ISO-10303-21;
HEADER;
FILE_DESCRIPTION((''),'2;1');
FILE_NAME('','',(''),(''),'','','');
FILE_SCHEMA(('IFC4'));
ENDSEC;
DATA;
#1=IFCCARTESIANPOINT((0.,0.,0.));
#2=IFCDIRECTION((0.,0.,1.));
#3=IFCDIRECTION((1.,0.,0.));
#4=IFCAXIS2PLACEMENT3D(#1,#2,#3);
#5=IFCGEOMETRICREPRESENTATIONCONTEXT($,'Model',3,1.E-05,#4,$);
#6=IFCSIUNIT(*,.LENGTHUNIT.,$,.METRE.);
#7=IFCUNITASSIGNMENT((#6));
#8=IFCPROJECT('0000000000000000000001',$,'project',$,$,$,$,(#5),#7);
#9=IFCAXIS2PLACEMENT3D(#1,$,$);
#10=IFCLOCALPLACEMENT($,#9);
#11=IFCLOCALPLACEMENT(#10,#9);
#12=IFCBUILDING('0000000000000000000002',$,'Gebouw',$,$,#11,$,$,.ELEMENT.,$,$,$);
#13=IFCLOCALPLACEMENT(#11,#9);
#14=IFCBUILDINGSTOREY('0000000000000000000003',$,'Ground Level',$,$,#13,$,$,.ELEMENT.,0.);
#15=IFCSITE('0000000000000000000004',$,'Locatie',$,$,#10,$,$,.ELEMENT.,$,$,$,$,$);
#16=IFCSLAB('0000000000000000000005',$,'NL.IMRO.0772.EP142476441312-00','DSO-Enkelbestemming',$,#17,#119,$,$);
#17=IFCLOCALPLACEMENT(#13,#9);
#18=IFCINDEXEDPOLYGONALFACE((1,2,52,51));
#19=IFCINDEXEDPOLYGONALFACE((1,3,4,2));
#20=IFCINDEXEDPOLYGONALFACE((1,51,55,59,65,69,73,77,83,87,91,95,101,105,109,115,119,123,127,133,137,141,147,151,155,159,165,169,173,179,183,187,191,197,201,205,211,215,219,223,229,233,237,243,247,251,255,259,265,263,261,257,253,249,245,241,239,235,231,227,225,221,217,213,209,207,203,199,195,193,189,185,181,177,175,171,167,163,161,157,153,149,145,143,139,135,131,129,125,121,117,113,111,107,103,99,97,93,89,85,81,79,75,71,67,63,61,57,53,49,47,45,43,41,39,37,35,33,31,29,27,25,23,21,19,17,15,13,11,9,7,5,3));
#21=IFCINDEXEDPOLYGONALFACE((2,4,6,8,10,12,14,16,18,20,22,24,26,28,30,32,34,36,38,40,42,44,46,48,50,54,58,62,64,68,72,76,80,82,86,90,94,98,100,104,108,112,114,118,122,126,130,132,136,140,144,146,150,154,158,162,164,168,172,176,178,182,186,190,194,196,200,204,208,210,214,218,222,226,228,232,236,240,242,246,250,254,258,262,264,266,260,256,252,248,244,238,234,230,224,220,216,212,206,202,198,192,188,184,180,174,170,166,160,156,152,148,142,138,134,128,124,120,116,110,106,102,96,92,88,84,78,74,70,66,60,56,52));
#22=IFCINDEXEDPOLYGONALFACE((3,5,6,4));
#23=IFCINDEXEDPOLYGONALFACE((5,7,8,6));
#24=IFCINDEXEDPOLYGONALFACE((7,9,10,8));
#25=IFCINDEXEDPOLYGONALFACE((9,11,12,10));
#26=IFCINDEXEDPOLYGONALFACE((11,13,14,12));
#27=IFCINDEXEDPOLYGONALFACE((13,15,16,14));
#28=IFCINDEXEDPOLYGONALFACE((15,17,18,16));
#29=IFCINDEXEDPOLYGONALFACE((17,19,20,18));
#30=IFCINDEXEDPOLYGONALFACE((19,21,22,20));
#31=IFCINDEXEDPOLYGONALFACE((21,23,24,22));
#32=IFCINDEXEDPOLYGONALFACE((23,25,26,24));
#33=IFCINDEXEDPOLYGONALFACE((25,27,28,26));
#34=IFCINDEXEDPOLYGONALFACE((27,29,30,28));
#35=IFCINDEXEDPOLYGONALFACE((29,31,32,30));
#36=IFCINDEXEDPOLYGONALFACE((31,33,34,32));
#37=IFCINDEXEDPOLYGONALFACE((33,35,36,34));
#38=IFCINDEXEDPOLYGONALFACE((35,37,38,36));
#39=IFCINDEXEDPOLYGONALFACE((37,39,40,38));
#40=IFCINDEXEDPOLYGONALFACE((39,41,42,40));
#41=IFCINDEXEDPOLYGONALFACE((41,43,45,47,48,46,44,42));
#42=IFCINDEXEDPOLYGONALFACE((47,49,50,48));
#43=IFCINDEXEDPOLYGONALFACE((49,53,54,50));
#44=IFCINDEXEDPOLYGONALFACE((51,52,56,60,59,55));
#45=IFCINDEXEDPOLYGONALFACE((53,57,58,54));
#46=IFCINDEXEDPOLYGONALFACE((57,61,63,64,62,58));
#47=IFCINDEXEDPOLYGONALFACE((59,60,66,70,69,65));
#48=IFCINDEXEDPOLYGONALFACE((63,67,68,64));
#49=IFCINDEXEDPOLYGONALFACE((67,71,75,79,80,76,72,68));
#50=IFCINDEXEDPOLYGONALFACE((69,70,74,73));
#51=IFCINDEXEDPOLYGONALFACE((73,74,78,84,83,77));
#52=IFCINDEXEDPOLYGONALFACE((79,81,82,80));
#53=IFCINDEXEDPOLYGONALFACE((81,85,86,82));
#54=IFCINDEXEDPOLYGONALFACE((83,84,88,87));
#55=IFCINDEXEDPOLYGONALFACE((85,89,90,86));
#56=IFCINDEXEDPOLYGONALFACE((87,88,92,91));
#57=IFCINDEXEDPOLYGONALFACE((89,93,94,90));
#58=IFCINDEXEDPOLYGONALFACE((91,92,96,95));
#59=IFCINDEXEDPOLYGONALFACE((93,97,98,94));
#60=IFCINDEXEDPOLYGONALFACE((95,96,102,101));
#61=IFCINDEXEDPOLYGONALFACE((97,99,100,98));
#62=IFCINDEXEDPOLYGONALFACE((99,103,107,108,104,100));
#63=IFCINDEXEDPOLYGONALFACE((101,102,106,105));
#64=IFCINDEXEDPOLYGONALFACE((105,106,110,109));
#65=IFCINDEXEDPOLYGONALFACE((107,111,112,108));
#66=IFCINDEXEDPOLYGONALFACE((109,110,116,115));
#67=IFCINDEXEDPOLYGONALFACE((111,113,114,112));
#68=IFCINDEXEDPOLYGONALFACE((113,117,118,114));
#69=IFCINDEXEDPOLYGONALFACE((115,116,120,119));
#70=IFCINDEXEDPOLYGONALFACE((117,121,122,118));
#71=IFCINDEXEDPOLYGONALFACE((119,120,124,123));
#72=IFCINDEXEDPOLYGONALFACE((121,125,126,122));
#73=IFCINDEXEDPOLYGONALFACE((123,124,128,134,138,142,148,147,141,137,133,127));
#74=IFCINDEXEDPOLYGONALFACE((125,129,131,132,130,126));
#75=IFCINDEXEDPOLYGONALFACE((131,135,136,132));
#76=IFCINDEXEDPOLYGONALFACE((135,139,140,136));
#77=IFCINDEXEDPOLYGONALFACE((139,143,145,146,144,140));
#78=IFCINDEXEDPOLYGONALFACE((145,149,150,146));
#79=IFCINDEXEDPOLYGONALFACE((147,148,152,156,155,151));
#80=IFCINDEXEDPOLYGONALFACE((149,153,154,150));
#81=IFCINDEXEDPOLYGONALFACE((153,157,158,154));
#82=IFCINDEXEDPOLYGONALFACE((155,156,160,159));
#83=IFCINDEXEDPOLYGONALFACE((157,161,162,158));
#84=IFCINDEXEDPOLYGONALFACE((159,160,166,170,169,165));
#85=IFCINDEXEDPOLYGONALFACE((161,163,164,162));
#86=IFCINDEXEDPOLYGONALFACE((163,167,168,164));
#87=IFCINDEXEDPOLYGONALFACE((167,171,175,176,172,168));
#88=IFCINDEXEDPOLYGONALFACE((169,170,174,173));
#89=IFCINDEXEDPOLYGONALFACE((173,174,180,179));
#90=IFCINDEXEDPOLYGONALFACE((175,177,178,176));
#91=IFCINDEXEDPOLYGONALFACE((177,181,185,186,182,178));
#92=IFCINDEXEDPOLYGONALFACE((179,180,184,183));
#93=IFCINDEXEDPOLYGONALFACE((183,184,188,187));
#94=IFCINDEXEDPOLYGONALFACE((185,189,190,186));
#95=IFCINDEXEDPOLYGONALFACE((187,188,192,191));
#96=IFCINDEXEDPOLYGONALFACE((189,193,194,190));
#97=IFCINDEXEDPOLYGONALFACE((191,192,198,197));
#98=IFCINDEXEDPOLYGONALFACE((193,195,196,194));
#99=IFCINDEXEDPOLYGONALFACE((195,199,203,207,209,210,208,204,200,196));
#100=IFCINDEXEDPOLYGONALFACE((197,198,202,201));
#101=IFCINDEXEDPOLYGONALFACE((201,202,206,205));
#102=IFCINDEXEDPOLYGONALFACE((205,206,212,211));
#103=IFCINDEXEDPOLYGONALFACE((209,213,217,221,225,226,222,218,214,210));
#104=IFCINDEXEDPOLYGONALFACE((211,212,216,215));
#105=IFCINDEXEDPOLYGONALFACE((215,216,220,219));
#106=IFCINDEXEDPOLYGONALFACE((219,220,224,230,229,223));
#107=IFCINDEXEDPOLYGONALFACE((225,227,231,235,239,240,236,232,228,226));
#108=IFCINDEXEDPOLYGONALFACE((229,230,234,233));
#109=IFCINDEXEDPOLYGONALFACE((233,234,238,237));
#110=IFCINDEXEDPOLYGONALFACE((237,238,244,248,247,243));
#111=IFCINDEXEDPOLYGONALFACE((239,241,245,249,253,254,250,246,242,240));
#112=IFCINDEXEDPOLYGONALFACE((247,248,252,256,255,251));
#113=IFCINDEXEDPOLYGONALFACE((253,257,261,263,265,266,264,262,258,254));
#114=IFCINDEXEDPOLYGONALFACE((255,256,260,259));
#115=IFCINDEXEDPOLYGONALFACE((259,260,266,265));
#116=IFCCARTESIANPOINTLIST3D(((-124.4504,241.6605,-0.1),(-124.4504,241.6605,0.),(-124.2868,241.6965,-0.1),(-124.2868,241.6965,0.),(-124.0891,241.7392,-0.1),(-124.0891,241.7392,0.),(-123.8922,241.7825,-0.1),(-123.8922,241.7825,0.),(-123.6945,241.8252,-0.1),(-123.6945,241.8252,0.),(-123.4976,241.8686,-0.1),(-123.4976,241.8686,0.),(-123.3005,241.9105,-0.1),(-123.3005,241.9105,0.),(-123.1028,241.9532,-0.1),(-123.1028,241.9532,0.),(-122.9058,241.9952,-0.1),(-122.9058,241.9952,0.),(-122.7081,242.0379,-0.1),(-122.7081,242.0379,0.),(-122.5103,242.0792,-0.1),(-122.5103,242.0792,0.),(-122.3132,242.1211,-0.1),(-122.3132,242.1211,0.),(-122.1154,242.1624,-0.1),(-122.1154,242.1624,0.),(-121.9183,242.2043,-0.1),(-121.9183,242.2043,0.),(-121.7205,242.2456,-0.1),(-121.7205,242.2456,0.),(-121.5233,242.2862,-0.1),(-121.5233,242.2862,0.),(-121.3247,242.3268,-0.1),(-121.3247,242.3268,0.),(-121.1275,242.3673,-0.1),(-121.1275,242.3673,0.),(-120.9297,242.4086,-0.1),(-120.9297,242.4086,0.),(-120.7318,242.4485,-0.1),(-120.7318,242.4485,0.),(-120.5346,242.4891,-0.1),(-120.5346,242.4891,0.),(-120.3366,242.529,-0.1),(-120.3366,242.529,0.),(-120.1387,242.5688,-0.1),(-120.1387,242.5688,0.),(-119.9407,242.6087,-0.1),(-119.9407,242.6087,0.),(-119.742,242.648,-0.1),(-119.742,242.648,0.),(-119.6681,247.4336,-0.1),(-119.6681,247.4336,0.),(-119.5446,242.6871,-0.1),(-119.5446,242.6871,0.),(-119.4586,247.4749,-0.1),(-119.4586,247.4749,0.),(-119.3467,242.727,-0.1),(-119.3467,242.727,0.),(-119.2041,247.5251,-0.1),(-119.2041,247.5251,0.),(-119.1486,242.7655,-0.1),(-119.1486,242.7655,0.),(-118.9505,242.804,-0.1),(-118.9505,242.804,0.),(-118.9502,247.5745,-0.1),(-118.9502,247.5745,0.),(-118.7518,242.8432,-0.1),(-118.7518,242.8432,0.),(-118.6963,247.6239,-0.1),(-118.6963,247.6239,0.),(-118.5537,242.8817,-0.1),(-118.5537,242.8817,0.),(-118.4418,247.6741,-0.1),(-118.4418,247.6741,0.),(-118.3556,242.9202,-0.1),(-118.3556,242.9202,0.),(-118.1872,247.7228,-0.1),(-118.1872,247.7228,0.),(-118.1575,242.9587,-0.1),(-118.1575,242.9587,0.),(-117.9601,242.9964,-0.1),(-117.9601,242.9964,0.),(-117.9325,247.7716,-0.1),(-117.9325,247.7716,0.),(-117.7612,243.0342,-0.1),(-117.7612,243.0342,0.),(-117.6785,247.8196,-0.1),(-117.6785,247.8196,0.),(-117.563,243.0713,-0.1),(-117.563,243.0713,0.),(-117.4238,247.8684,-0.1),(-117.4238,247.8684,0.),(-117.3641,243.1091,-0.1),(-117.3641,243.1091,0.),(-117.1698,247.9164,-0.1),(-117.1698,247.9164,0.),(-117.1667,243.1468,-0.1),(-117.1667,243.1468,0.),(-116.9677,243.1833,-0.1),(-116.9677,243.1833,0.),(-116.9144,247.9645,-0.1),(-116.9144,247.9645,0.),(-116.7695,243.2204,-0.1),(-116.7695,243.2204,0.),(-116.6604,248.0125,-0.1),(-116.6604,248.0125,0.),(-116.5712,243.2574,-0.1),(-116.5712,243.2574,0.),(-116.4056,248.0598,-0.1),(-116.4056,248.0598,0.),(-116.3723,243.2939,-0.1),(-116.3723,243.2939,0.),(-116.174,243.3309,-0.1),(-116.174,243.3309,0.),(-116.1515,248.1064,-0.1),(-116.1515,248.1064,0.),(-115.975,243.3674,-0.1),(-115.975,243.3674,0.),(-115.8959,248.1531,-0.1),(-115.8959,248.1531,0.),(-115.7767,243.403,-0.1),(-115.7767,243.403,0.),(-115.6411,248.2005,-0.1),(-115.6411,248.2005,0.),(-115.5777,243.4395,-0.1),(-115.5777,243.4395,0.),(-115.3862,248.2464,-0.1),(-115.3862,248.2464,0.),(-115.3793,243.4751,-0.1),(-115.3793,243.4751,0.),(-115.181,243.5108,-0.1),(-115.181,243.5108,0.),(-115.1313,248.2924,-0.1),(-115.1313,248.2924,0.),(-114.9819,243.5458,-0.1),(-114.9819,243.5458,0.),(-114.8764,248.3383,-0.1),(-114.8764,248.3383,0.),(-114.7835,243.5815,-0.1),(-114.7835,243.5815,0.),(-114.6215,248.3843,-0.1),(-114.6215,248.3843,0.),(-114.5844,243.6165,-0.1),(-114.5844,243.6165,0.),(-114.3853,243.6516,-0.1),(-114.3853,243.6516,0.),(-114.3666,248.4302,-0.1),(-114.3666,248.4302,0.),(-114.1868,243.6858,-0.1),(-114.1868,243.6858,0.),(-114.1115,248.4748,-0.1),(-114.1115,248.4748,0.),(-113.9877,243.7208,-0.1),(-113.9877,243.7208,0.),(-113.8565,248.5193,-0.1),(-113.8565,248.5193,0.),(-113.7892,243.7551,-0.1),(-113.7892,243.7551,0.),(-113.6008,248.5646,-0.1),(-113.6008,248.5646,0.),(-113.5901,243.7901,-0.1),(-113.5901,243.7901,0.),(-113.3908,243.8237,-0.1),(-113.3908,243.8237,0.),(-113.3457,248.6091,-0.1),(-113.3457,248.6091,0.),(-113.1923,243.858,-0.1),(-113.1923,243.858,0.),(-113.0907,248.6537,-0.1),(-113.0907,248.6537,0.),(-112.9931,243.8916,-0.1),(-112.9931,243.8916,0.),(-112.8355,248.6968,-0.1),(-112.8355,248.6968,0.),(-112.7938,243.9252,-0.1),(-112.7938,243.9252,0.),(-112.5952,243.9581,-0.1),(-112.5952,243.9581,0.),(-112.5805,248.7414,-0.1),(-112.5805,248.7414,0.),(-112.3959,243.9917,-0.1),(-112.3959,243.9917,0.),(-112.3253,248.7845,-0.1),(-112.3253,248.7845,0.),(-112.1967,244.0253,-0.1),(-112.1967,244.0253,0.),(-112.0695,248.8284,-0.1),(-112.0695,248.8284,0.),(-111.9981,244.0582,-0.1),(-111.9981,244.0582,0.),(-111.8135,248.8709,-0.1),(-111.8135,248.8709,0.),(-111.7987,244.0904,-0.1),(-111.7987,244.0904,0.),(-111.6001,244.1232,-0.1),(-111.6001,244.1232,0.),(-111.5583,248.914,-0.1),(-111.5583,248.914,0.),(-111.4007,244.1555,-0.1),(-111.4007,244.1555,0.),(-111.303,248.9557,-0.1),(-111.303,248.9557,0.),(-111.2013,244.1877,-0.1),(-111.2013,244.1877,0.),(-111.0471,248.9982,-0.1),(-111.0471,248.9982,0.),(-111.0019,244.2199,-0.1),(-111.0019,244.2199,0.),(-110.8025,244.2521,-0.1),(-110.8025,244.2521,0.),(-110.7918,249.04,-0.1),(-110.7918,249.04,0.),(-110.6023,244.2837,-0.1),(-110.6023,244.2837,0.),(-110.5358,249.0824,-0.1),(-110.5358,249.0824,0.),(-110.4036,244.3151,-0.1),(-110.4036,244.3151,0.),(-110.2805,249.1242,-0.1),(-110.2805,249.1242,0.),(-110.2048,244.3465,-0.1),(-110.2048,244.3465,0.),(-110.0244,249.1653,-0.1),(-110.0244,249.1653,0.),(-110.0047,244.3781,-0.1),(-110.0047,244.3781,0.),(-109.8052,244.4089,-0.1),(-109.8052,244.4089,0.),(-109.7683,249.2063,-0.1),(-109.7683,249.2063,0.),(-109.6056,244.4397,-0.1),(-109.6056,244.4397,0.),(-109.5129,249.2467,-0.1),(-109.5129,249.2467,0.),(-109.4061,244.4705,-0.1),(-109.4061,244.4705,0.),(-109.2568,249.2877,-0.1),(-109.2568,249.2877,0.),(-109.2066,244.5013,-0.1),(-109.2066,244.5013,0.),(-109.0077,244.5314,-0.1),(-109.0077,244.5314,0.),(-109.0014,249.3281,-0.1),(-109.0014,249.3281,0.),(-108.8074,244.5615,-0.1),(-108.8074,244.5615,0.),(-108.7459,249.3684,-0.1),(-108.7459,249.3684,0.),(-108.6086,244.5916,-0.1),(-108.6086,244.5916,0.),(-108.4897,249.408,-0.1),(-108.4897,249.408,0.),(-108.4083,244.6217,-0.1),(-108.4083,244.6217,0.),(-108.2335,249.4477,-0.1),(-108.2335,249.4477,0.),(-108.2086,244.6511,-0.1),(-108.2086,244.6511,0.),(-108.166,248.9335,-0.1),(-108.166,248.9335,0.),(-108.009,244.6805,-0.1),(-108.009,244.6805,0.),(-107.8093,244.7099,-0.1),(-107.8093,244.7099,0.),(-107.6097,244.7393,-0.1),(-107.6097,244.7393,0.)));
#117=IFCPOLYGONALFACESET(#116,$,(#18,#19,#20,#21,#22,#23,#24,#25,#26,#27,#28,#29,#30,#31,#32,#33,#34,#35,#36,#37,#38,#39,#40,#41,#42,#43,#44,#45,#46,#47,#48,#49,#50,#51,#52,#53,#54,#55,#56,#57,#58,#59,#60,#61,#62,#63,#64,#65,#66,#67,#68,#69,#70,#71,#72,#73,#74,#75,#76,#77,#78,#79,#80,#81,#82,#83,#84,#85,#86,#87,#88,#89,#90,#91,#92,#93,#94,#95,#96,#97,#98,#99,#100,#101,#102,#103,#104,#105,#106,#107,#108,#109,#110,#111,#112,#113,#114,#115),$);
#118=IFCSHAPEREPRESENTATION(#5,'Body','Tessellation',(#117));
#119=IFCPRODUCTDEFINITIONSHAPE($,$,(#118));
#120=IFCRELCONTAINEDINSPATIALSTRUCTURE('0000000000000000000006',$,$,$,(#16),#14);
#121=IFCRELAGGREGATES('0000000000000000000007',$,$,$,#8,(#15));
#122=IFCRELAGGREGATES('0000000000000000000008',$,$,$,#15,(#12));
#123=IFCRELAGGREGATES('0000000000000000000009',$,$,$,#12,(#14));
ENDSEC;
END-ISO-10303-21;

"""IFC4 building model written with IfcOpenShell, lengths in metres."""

from ifc_helpers import new_model, si_unit, frame, origin, origin_with_axes, place, context, project, spatial, polyline, outline, extrude, element, save


model = new_model("IFC4")

# Units and contexts
model_context = context("Model", 3, precision=1e-05, world=origin_with_axes())
ifc_project = project(units=[si_unit("LENGTHUNIT", "METRE")], contexts=[model_context])

# Site, building, storey
site_placement = place(None, origin())
site = spatial("IfcSite", under=ifc_project, at=site_placement, Name="Locatie", CompositionType="ELEMENT")
building_placement = place(site_placement, origin())
building = spatial("IfcBuilding", under=site, at=building_placement, Name="Gebouw", CompositionType="ELEMENT")
storey_placement = place(building_placement, origin())
storey = spatial("IfcBuildingStorey", under=building, at=storey_placement, Name="Ground Level", CompositionType="ELEMENT", Elevation=0.0)

# Slab
slab_1_placement = place(storey_placement, origin())
element("IfcSlab", 1, at=slab_1_placement, inside=storey, Name="NL.IMRO.0772.EP142476441312-00", Description="DSO-Enkelbestemming", context=model_context, shape_type="SweptSolid", body=[
    extrude(outline(polyline([(-119.4586, 247.4749), (-119.2041, 247.5251), (-118.9502, 247.5745), (-118.6963, 247.6239), (-118.4418, 247.6741), (-118.1872, 247.7228), (-117.9325, 247.7716), (-117.6785, 247.8196), (-117.4238, 247.8684), (-117.1698, 247.9164), (-116.9144, 247.9645), (-116.6604, 248.0125), (-116.4056, 248.0598), (-116.1515, 248.1064), (-115.8959, 248.1531), (-115.6411, 248.2005), (-115.3862, 248.2464), (-115.1313, 248.2924), (-114.8764, 248.3383), (-114.6215, 248.3843), (-114.3666, 248.4302), (-114.1115, 248.4748), (-113.8565, 248.5193), (-113.6008, 248.5646), (-113.3457, 248.6091), (-113.0907, 248.6537), (-112.8355, 248.6968), (-112.5805, 248.7414), (-112.3253, 248.7845), (-112.0695, 248.8284), (-111.8135, 248.8709), (-111.5583, 248.914), (-111.303, 248.9557), (-111.0471, 248.9982), (-110.7918, 249.04), (-110.5358, 249.0824), (-110.2805, 249.1242), (-110.0244, 249.1653), (-109.7683, 249.2063), (-109.5129, 249.2467), (-109.2568, 249.2877), (-109.0014, 249.3281), (-108.7459, 249.3684), (-108.4897, 249.408), (-108.2335, 249.4477), (-108.166, 248.9335), (-107.6097, 244.7393), (-107.8093, 244.7099), (-108.009, 244.6805), (-108.2086, 244.6511), (-108.4083, 244.6217), (-108.6086, 244.5916), (-108.8074, 244.5615), (-109.0077, 244.5314), (-109.2066, 244.5013), (-109.4061, 244.4705), (-109.6056, 244.4397), (-109.8052, 244.4089), (-110.0047, 244.3781), (-110.2048, 244.3465), (-110.4036, 244.3151), (-110.6023, 244.2837), (-110.8025, 244.2521), (-111.0019, 244.2199), (-111.2013, 244.1877), (-111.4007, 244.1555), (-111.6001, 244.1232), (-111.7987, 244.0904), (-111.9981, 244.0582), (-112.1967, 244.0253), (-112.3959, 243.9917), (-112.5952, 243.9581), (-112.7938, 243.9252), (-112.9931, 243.8916), (-113.1923, 243.858), (-113.3908, 243.8237), (-113.5901, 243.7901), (-113.7892, 243.7551), (-113.9877, 243.7208), (-114.1868, 243.6858), (-114.3853, 243.6516), (-114.5844, 243.6165), (-114.7835, 243.5815), (-114.9819, 243.5458), (-115.181, 243.5108), (-115.3793, 243.4751), (-115.5777, 243.4395), (-115.7767, 243.403), (-115.975, 243.3674), (-116.174, 243.3309), (-116.3723, 243.2939), (-116.5712, 243.2574), (-116.7695, 243.2204), (-116.9677, 243.1833), (-117.1667, 243.1468), (-117.3641, 243.1091), (-117.563, 243.0713), (-117.7612, 243.0342), (-117.9601, 242.9964), (-118.1575, 242.9587), (-118.3556, 242.9202), (-118.5537, 242.8817), (-118.7518, 242.8432), (-118.9505, 242.804), (-119.1486, 242.7655), (-119.3467, 242.727), (-119.5446, 242.6871), (-119.742, 242.648), (-119.9407, 242.6087), (-120.1387, 242.5688), (-120.3366, 242.529), (-120.5346, 242.4891), (-120.7318, 242.4485), (-120.9297, 242.4086), (-121.1275, 242.3673), (-121.3247, 242.3268), (-121.5233, 242.2862), (-121.7205, 242.2456), (-121.9183, 242.2043), (-122.1154, 242.1624), (-122.3132, 242.1211), (-122.5103, 242.0792), (-122.7081, 242.0379), (-122.9058, 241.9952), (-123.1028, 241.9532), (-123.3005, 241.9105), (-123.4976, 241.8686), (-123.6945, 241.8252), (-123.8922, 241.7825), (-124.0891, 241.7392), (-124.2868, 241.6965), (-124.4504, 241.6605), (-119.6681, 247.4336), (-119.4586, 247.4749)])), frame((0.0, 0.0, -0.1), z_axis=(0.0, 0.0, 1.0), x_axis=(1.0, 0.0, 0.0)), (0.0, 0.0, 1.0), 0.1),
])

save(model, "model.ifc")
